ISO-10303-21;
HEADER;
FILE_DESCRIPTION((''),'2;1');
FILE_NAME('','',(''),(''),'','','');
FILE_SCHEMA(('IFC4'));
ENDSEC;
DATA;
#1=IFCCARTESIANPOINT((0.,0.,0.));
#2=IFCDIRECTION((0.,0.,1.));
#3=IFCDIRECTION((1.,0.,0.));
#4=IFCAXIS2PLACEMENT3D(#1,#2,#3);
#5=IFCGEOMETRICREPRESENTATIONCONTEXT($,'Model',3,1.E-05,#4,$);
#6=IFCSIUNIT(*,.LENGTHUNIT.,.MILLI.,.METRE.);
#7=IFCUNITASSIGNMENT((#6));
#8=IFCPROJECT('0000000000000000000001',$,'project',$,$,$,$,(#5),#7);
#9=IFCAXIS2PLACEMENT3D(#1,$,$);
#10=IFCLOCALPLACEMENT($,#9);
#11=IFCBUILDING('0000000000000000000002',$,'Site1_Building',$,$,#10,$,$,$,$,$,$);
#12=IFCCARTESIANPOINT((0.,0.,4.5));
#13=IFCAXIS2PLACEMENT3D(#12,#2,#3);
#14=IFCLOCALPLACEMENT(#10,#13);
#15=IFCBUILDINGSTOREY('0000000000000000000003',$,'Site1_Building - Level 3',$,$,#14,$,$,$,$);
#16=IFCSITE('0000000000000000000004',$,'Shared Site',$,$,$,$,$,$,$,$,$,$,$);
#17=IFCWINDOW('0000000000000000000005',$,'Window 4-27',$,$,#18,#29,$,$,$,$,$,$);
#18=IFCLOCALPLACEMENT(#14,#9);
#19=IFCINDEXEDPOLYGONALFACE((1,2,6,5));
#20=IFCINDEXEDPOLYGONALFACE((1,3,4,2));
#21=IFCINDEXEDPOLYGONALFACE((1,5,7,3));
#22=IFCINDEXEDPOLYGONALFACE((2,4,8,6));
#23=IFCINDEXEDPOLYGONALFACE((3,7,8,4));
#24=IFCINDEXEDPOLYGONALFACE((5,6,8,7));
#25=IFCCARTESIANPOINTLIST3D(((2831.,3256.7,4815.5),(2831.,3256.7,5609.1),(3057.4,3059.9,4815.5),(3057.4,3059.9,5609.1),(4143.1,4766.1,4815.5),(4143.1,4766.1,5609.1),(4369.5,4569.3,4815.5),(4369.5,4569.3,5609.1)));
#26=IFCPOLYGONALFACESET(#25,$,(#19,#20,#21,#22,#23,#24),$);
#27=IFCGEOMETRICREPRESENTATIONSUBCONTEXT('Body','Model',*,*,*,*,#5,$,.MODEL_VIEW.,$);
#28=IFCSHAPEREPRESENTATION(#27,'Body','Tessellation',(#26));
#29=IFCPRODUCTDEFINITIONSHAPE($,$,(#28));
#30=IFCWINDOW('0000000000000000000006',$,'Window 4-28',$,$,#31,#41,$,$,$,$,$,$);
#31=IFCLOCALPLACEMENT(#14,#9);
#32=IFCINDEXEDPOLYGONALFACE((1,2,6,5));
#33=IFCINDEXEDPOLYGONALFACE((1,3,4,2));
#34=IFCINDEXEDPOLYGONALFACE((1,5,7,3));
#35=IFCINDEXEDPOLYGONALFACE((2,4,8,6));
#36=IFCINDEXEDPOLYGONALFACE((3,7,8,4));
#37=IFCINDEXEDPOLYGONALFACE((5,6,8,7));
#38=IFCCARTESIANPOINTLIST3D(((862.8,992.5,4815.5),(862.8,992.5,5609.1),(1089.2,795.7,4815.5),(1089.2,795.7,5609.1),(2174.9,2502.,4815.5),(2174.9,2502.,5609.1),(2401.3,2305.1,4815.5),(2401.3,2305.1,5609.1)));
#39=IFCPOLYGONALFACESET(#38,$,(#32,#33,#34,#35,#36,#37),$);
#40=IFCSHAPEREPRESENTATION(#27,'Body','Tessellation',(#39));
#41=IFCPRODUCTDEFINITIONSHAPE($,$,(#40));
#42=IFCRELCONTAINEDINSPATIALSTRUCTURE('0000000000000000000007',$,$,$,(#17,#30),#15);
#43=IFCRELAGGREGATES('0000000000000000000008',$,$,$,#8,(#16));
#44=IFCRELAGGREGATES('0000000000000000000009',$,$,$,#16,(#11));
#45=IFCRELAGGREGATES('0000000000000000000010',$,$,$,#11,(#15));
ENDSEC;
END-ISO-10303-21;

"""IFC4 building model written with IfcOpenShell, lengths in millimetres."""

from ifc_helpers import new_model, si_unit, frame, origin, origin_with_axes, place, context, subcontext, project, spatial, indexed_curve, outline, extrude, element, save


model = new_model("IFC4")

# Units and contexts
model_context = context("Model", 3, precision=1e-05, world=origin_with_axes())
body_context = subcontext(model_context, "Body", "Model", "MODEL_VIEW")
ifc_project = project(units=[si_unit("LENGTHUNIT", "METRE", prefix="MILLI")], contexts=[model_context])

# Site, building, storey
site = spatial("IfcSite", under=ifc_project, Name="Shared Site")
building_placement = place(None, origin())
building = spatial("IfcBuilding", under=site, at=building_placement, Name="Site1_Building")
storey_placement = place(building_placement, frame((0.0, 0.0, 4.5), z_axis=(0.0, 0.0, 1.0), x_axis=(1.0, 0.0, 0.0)))
storey = spatial("IfcBuildingStorey", under=building, at=storey_placement, Name="Site1_Building - Level 3")

# Windows
for number, where, z_axis, x_axis, name in (
    (1, (4143.1, 4766.1, 4815.5), (0.0, 0.0, 1.0), (-0.656059, -0.75471, 0.0), "Window 4-27"),
    (2, (2174.9, 2502.0, 4815.5), (0.0, 0.0, 1.0), (-0.656059, -0.75471, 0.0), "Window 4-28"),
):
    element("IfcWindow", number, at=place(storey_placement, frame(where, z_axis=z_axis, x_axis=x_axis)), inside=storey, Name=name, context=body_context, shape_type="SweptSolid", body=[
        extrude(outline(indexed_curve([(0.0, 0.0), (0.0, 300.0), (2000.0, 300.0), (2000.0, 0.0), (0.0, 0.0)], self_intersect=False)), origin_with_axes(), (0.0, 0.0, 1.0), 793.6),
    ])

save(model, "model.ifc")
